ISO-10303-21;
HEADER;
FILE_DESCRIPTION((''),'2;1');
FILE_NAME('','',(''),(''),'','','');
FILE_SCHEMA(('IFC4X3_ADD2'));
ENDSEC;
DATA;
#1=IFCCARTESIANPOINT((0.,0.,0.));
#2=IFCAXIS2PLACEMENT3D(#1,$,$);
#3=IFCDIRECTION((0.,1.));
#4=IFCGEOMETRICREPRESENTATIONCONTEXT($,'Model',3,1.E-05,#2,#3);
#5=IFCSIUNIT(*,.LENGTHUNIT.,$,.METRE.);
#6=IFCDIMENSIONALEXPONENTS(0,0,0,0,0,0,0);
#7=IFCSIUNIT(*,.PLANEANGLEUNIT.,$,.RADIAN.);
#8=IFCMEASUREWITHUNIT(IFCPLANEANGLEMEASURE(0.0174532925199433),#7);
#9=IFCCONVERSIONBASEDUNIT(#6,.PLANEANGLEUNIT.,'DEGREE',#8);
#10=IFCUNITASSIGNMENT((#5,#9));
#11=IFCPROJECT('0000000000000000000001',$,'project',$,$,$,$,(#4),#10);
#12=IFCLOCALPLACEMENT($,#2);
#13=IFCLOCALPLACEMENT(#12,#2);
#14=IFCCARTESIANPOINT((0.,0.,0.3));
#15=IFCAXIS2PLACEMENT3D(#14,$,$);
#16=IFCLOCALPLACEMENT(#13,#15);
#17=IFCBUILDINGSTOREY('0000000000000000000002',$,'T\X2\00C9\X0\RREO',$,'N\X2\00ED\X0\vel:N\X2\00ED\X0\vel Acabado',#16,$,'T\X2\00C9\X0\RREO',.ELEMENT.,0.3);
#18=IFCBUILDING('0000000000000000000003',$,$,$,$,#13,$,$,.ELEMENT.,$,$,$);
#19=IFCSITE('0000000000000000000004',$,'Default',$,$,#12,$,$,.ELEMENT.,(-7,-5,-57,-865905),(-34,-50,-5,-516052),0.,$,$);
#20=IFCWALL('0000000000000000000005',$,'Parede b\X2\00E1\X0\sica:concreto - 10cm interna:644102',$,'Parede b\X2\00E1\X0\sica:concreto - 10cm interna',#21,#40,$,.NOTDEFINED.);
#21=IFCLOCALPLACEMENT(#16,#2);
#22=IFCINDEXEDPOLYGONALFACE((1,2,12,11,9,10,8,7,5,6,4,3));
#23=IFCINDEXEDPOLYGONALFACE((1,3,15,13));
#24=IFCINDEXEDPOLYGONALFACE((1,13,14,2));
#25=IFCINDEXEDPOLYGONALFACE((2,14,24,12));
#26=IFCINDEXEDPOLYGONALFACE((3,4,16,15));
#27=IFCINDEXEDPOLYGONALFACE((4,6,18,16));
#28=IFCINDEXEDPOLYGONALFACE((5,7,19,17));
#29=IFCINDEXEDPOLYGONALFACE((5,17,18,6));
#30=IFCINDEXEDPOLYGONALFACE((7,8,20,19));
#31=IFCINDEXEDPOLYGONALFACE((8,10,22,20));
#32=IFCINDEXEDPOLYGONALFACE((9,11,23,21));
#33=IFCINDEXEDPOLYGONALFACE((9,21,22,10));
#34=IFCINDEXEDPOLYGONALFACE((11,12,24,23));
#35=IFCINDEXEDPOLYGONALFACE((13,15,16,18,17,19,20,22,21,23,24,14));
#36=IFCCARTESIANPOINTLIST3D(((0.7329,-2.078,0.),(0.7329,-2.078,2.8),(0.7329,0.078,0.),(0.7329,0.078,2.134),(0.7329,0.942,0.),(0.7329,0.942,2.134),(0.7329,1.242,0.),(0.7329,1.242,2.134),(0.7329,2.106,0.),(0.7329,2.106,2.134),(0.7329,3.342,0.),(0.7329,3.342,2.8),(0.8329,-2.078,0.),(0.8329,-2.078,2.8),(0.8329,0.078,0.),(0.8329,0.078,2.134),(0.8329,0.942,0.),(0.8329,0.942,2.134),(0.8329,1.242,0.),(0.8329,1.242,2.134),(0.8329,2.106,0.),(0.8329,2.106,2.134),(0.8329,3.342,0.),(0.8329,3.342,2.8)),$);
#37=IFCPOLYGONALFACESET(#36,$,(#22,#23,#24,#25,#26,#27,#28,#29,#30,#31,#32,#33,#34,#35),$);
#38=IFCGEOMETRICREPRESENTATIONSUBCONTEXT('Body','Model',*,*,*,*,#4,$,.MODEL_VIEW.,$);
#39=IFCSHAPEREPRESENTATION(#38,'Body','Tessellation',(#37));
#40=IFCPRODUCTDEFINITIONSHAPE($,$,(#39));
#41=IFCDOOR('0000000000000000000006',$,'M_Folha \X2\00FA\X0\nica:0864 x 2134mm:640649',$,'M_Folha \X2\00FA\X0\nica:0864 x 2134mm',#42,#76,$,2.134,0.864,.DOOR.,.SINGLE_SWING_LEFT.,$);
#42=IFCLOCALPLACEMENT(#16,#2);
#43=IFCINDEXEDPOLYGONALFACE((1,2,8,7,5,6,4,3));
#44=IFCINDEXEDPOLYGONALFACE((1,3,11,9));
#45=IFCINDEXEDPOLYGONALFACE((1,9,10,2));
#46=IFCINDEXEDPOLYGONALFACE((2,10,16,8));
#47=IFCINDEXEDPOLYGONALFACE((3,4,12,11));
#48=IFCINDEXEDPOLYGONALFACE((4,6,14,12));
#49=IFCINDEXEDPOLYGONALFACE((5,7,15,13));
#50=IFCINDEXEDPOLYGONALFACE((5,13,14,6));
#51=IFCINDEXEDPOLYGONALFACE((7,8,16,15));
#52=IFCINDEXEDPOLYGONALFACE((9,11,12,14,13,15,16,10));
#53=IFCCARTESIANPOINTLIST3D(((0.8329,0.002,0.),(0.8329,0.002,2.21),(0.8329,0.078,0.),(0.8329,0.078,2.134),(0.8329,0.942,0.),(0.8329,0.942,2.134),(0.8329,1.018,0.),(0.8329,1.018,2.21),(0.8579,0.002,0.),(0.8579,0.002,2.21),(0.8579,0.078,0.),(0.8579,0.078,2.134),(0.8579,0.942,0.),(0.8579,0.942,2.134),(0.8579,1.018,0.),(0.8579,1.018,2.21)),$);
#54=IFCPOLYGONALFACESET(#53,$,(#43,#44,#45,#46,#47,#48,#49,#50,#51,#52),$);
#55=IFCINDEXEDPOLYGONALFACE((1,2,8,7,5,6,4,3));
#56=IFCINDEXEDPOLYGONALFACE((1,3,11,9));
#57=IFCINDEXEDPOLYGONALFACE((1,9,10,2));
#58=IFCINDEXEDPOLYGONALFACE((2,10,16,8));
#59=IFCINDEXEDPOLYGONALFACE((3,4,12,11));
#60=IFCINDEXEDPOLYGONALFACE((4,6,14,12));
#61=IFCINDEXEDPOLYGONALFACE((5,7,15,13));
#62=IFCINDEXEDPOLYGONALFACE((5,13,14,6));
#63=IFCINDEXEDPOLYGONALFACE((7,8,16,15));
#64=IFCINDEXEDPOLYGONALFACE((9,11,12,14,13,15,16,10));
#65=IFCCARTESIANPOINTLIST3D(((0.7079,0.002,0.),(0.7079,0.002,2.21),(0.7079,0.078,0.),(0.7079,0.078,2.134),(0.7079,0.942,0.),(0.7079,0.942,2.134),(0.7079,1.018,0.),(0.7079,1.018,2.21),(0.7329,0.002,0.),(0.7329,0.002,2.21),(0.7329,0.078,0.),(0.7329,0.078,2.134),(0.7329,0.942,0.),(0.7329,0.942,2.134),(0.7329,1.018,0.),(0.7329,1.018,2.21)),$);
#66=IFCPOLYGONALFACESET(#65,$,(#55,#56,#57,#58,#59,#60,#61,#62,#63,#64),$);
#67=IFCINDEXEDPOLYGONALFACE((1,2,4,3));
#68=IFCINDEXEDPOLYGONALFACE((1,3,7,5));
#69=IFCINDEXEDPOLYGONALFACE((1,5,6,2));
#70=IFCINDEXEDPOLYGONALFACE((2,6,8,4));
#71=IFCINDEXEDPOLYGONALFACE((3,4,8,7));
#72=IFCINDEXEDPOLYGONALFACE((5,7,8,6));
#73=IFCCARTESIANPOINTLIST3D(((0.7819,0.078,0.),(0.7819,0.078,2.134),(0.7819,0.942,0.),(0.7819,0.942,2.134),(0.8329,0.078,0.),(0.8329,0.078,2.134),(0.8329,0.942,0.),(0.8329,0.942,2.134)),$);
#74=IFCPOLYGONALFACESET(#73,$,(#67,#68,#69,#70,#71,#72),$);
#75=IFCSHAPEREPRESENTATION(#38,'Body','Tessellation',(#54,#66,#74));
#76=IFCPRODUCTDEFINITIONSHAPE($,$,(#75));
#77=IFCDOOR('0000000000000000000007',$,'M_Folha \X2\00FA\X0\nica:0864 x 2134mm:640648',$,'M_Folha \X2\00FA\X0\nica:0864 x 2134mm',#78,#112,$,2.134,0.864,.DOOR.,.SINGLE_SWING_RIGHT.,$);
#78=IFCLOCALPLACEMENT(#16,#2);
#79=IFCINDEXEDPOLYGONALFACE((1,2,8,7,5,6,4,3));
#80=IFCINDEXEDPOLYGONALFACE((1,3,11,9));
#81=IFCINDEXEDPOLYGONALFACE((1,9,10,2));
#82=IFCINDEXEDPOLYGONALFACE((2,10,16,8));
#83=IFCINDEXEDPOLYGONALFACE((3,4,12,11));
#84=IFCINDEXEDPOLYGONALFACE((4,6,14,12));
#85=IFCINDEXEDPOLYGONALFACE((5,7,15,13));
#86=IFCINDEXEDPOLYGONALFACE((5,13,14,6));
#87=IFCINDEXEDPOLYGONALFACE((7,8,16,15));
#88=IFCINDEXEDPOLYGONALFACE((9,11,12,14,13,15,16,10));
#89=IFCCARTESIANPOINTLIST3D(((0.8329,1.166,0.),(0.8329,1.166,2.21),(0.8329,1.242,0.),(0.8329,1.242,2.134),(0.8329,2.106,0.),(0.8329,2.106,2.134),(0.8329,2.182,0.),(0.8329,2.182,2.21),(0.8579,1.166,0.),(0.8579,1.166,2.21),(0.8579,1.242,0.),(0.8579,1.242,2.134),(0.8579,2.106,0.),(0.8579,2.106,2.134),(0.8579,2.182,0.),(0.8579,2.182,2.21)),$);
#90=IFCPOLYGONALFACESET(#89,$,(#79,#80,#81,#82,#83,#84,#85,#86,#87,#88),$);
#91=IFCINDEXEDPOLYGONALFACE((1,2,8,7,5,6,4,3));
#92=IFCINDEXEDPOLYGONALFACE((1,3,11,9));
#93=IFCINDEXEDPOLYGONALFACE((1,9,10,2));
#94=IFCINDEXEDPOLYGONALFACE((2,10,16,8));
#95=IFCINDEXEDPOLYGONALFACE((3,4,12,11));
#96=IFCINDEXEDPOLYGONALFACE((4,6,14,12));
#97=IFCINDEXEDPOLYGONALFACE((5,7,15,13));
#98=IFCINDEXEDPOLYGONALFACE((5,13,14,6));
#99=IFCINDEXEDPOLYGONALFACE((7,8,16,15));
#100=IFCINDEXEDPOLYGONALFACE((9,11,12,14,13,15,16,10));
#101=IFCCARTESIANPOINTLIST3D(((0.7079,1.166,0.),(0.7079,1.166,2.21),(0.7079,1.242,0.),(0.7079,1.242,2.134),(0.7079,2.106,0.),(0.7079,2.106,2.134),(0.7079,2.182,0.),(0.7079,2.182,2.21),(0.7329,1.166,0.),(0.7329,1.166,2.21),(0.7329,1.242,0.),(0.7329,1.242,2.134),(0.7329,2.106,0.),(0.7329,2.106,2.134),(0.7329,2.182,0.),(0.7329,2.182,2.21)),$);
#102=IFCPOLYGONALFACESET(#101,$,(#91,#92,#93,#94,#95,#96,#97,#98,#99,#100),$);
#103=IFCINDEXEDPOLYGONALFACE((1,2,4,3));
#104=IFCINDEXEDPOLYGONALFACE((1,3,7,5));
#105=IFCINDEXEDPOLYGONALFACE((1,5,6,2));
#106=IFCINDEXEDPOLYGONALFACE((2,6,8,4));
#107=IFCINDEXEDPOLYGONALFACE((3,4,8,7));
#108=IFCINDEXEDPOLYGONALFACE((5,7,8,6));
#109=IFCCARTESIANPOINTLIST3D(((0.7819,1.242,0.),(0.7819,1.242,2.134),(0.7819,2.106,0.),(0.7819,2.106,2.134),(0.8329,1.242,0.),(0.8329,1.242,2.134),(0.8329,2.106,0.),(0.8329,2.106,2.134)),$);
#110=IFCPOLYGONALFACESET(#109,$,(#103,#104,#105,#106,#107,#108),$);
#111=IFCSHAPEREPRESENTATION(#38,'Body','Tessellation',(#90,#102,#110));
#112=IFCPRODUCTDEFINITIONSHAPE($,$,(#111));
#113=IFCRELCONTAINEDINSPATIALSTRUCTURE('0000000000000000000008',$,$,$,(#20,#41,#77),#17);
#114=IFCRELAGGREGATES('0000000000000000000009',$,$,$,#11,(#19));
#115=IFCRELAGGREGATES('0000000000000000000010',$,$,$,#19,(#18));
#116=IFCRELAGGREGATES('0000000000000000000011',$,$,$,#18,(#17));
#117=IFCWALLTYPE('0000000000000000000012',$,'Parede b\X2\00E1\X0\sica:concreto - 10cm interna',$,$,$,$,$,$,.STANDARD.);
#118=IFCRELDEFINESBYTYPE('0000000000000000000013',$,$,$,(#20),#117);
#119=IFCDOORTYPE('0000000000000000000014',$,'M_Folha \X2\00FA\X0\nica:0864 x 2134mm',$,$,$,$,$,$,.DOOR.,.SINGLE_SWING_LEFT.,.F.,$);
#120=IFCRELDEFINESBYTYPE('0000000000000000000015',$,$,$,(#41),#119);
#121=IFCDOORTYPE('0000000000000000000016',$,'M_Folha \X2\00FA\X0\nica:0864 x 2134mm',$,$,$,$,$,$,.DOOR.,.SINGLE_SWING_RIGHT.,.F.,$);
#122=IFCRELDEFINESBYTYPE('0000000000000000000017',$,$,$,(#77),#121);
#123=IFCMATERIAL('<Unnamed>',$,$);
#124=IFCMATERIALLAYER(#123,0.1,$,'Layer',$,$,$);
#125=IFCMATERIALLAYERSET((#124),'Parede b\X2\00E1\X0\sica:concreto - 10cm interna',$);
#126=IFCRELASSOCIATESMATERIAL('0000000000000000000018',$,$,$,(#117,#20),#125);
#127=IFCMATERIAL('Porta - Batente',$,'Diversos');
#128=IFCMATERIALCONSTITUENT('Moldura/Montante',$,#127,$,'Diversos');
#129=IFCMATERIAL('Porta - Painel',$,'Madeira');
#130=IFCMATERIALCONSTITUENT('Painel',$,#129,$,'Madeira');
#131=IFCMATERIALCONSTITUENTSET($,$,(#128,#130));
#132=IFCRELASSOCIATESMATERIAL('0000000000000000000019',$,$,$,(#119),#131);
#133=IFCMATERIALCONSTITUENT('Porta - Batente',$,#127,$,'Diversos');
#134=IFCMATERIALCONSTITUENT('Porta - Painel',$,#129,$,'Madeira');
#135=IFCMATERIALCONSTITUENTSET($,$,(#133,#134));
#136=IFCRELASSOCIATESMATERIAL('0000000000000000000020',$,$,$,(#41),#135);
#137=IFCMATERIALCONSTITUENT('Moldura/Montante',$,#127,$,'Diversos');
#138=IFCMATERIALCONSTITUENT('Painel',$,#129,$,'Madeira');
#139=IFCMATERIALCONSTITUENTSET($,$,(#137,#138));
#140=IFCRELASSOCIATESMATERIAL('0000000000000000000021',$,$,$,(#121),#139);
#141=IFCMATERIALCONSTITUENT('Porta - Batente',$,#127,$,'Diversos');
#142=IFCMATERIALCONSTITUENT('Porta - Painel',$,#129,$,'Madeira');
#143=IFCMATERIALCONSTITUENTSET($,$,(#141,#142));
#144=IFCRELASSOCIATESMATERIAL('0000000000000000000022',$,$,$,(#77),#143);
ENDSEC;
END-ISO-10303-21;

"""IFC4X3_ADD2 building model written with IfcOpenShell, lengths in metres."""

from ifc_helpers import new_model, entity, si_unit, converted_unit, direction, frame, frame_2d, origin, origin_2d_with_axis, place, context, subcontext, project, spatial, polyline, rectangle, outline, extrude, source, transform, mapped, material, layer, layer_set, constituent, constituent_set, type_object, type_shapes, element, fill, save


model = new_model("IFC4X3_ADD2")

# Units and contexts
model_context = context("Model", 3, precision=1e-05, world=origin(), true_north=direction((0.0, 1.0)))
body_context = subcontext(model_context, "Body", "Model", "MODEL_VIEW")
ifc_project = project(units=[si_unit("LENGTHUNIT", "METRE"), converted_unit("PLANEANGLEUNIT", "DEGREE", entity("IfcPlaneAngleMeasure", 0.0174532925199433), si_unit("PLANEANGLEUNIT", "RADIAN"), dimensions=[0, 0, 0, 0, 0, 0, 0])], contexts=[model_context])

# Site, building, storey
site_placement = place(None, origin())
site = spatial("IfcSite", under=ifc_project, at=site_placement, Name="Default", CompositionType="ELEMENT", RefLatitude=(-7, -5, -57, -865905), RefLongitude=(-34, -50, -5, -516052), RefElevation=0.0)
building_placement = place(site_placement, origin())
building = spatial("IfcBuilding", under=site, at=building_placement, CompositionType="ELEMENT")
storey_placement = place(building_placement, frame((0.0, 0.0, 0.3)))
storey = spatial("IfcBuildingStorey", under=building, at=storey_placement, Name="TÉRREO", ObjectType="Nível:Nível Acabado", LongName="TÉRREO", CompositionType="ELEMENT", Elevation=0.3)

# Shared definitions
ifc_material_1 = material(Name="<Unnamed>")

# Shared definitions
ifc_material_2 = material(Name="Porta - Batente", Category="Diversos")
ifc_material_3 = material(Name="Porta - Painel", Category="Madeira")

# Shared definitions
ifc_layer_1 = layer(ifc_material_1, 0.1, Name="Layer")
ifc_layer_set_1 = layer_set([ifc_layer_1], Name="Parede básica:concreto - 10cm interna")
wall_type_1 = type_object("IfcWallType", Name="Parede básica:concreto - 10cm interna", PredefinedType="STANDARD", material=ifc_layer_set_1)

# Shared definitions
ifc_constituent_1 = constituent(ifc_material_2, Name="Moldura/Montante", Category="Diversos")
ifc_constituent_2 = constituent(ifc_material_3, Name="Painel", Category="Madeira")
ifc_constituent_set_1 = constituent_set(constituents=[ifc_constituent_1, ifc_constituent_2])
door_type_1 = type_object("IfcDoorType", Name="M_Folha única:0864 x 2134mm", OperationType="SINGLE_SWING_LEFT", ParameterTakesPrecedence=False, PredefinedType="DOOR", material=ifc_constituent_set_1)
shared_shape_1 = source(origin(), body_context, "Body", "SweptSolid", [
    extrude(outline(polyline([(-0.508, -1.124), (0.508, -1.124), (0.508, 1.086), (0.432, 1.086), (0.432, -1.048), (-0.432, -1.048), (-0.432, 1.086), (-0.508, 1.086), (-0.508, -1.124)])), frame((0.432, 0.125, 1.086), z_axis=(0.0, -1.0, 0.0), x_axis=(-1.0, 0.0, 0.0)), (0.0, 0.0, 1.0), 0.025),
    extrude(outline(polyline([(-1.124, -0.508), (1.086, -0.508), (1.086, -0.432), (-1.048, -0.432), (-1.048, 0.432), (1.086, 0.432), (1.086, 0.508), (-1.124, 0.508), (-1.124, -0.508)])), frame((0.432, 0.0, 1.086), z_axis=(0.0, -1.0, 0.0), x_axis=(0.0, 0.0, -1.0)), (0.0, 0.0, 1.0), 0.025),
    extrude(rectangle(XDim=0.864, YDim=0.051, at=origin_2d_with_axis()), frame((0.432, 0.0745, 0.0)), (0.0, 0.0, 1.0), 2.134),
])
type_shapes(door_type_1, [shared_shape_1])

# Wall, openings, doors
wall_1_placement = place(storey_placement, frame((0.7829, -2.078, 0.0), z_axis=(0.0, 0.0, 1.0), x_axis=(0.0, 1.0, 0.0)))
wall_1 = element("IfcWall", 1, at=wall_1_placement, inside=storey, type_object=wall_type_1, material=ifc_layer_set_1, Name="Parede básica:concreto - 10cm interna:644102", ObjectType="Parede básica:concreto - 10cm interna", PredefinedType="NOTDEFINED", context=body_context, shape_type="SweptSolid", body=[
    extrude(rectangle(XDim=5.42, YDim=0.1, at=frame_2d((2.71, 0.0), x_axis=(1.0, 0.0))), origin(), (0.0, 0.0, 1.0), 2.8),
])
opening_1_placement = place(wall_1_placement, frame((4.184, 0.05, 0.0)))
opening_1 = element("IfcOpeningElement", 2, at=opening_1_placement, cuts=wall_1, PredefinedType="OPENING", context=body_context, shape_type="SweptSolid", body=[
    extrude(rectangle(XDim=0.864, YDim=2.134, at=frame_2d((1.067, 0.432), x_axis=(0.0, 1.0))), frame((0.0, 0.0, 0.0), z_axis=(0.0, -1.0, 0.0), x_axis=(0.0, 0.0, 1.0)), (0.0, 0.0, 1.0), 0.1),
])
opening_2_placement = place(wall_1_placement, frame((2.078, 0.7829, 0.0), z_axis=(0.0, 0.0, 1.0), x_axis=(0.0, -1.0, 0.0)))
element("IfcOpeningElement", 3, at=opening_2_placement, cuts=wall_1, PredefinedType="OPENING", context=body_context, shape_type="SweptSolid", body=[
    extrude(rectangle(XDim=2.134, YDim=0.864, at=frame_2d((0.0, 0.0), x_axis=(0.0, 1.0))), frame((2.2569, 1.674, 1.067), z_axis=(-1.0, 0.0, 0.0), x_axis=(0.0, -1.0, 0.0)), (0.0, 0.0, 1.0), 3.048),
])
opening_3_placement = place(wall_1_placement, frame((3.02, 0.05, 0.0)))
opening_3 = element("IfcOpeningElement", 4, at=opening_3_placement, cuts=wall_1, PredefinedType="OPENING", context=body_context, shape_type="SweptSolid", body=[
    extrude(rectangle(XDim=0.864, YDim=2.134, at=frame_2d((1.067, 0.432), x_axis=(0.0, -1.0))), frame((0.0, 0.0, 0.0), z_axis=(0.0, -1.0, 0.0), x_axis=(0.0, 0.0, 1.0)), (0.0, 0.0, 1.0), 0.1),
])
opening_4_placement = place(wall_1_placement, frame((2.078, 0.7829, 0.0), z_axis=(0.0, 0.0, 1.0), x_axis=(0.0, -1.0, 0.0)))
element("IfcOpeningElement", 5, at=opening_4_placement, cuts=wall_1, PredefinedType="OPENING", context=body_context, shape_type="SweptSolid", body=[
    extrude(rectangle(XDim=2.134, YDim=0.864, at=frame_2d((0.0, 0.0), x_axis=(1.0, 0.0))), frame((2.2569, 0.51, 1.067), z_axis=(-1.0, 0.0, 0.0), x_axis=(0.0, 0.0, 1.0)), (0.0, 0.0, 1.0), 3.048),
])
ifc_constituent_3 = constituent(ifc_material_2, Name="Porta - Batente", Category="Diversos")
ifc_constituent_4 = constituent(ifc_material_3, Name="Porta - Painel", Category="Madeira")
ifc_constituent_set_2 = constituent_set(constituents=[ifc_constituent_3, ifc_constituent_4])
door_1_placement = place(opening_3_placement, frame((0.0, 0.0, 0.0), z_axis=(0.0, 0.0, 1.0), x_axis=(-1.0, 0.0, 0.0)))
door_1 = element("IfcDoor", 6, at=door_1_placement, inside=storey, type_object=door_type_1, material=ifc_constituent_set_2, Name="M_Folha única:0864 x 2134mm:640649", ObjectType="M_Folha única:0864 x 2134mm", OperationType="SINGLE_SWING_LEFT", OverallHeight=2.134, OverallWidth=0.864, PredefinedType="DOOR", context=body_context, shape_type="MappedRepresentation", body=[
    mapped(shared_shape_1, transform((0.0, 0.0, 0.0), scale=1.0)),
])
fill(opening_3, door_1)
ifc_constituent_5 = constituent(ifc_material_2, Name="Porta - Batente", Category="Diversos")
ifc_constituent_6 = constituent(ifc_material_3, Name="Porta - Painel", Category="Madeira")
ifc_constituent_set_3 = constituent_set(constituents=[ifc_constituent_5, ifc_constituent_6])
ifc_constituent_7 = constituent(ifc_material_2, Name="Moldura/Montante", Category="Diversos")
ifc_constituent_8 = constituent(ifc_material_3, Name="Painel", Category="Madeira")
ifc_constituent_set_4 = constituent_set(constituents=[ifc_constituent_7, ifc_constituent_8])
door_type_2 = type_object("IfcDoorType", Name="M_Folha única:0864 x 2134mm", OperationType="SINGLE_SWING_RIGHT", ParameterTakesPrecedence=False, PredefinedType="DOOR", material=ifc_constituent_set_4)
shared_shape_2 = source(origin(), body_context, "Body", "SweptSolid", [
    extrude(outline(polyline([(-0.508, -1.124), (0.508, -1.124), (0.508, 1.086), (0.432, 1.086), (0.432, -1.048), (-0.432, -1.048), (-0.432, 1.086), (-0.508, 1.086), (-0.508, -1.124)])), frame((0.432, 0.1, 1.086), z_axis=(0.0, 1.0, 0.0), x_axis=(1.0, 0.0, 0.0)), (0.0, 0.0, 1.0), 0.025),
    extrude(outline(polyline([(-1.124, -0.508), (1.086, -0.508), (1.086, -0.432), (-1.048, -0.432), (-1.048, 0.432), (1.086, 0.432), (1.086, 0.508), (-1.124, 0.508), (-1.124, -0.508)])), frame((0.432, -0.025, 1.086), z_axis=(0.0, 1.0, 0.0), x_axis=(0.0, 0.0, -1.0)), (0.0, 0.0, 1.0), 0.025),
    extrude(rectangle(XDim=0.051, YDim=0.864, at=origin_2d_with_axis()), frame((0.432, 0.0745, 0.0), z_axis=(0.0, 0.0, 1.0), x_axis=(0.0, 1.0, 0.0)), (0.0, 0.0, 1.0), 2.134),
])
type_shapes(door_type_2, [shared_shape_2])
door_2_placement = place(opening_1_placement, frame((0.0, 0.0, 0.0), z_axis=(0.0, 0.0, 1.0), x_axis=(-1.0, 0.0, 0.0)))
door_2 = element("IfcDoor", 7, at=door_2_placement, inside=storey, type_object=door_type_2, material=ifc_constituent_set_3, Name="M_Folha única:0864 x 2134mm:640648", ObjectType="M_Folha única:0864 x 2134mm", OperationType="SINGLE_SWING_RIGHT", OverallHeight=2.134, OverallWidth=0.864, PredefinedType="DOOR", context=body_context, shape_type="MappedRepresentation", body=[
    mapped(shared_shape_2, transform((0.0, 0.0, 0.0), scale=1.0)),
])
fill(opening_1, door_2)

save(model, "model.ifc")
